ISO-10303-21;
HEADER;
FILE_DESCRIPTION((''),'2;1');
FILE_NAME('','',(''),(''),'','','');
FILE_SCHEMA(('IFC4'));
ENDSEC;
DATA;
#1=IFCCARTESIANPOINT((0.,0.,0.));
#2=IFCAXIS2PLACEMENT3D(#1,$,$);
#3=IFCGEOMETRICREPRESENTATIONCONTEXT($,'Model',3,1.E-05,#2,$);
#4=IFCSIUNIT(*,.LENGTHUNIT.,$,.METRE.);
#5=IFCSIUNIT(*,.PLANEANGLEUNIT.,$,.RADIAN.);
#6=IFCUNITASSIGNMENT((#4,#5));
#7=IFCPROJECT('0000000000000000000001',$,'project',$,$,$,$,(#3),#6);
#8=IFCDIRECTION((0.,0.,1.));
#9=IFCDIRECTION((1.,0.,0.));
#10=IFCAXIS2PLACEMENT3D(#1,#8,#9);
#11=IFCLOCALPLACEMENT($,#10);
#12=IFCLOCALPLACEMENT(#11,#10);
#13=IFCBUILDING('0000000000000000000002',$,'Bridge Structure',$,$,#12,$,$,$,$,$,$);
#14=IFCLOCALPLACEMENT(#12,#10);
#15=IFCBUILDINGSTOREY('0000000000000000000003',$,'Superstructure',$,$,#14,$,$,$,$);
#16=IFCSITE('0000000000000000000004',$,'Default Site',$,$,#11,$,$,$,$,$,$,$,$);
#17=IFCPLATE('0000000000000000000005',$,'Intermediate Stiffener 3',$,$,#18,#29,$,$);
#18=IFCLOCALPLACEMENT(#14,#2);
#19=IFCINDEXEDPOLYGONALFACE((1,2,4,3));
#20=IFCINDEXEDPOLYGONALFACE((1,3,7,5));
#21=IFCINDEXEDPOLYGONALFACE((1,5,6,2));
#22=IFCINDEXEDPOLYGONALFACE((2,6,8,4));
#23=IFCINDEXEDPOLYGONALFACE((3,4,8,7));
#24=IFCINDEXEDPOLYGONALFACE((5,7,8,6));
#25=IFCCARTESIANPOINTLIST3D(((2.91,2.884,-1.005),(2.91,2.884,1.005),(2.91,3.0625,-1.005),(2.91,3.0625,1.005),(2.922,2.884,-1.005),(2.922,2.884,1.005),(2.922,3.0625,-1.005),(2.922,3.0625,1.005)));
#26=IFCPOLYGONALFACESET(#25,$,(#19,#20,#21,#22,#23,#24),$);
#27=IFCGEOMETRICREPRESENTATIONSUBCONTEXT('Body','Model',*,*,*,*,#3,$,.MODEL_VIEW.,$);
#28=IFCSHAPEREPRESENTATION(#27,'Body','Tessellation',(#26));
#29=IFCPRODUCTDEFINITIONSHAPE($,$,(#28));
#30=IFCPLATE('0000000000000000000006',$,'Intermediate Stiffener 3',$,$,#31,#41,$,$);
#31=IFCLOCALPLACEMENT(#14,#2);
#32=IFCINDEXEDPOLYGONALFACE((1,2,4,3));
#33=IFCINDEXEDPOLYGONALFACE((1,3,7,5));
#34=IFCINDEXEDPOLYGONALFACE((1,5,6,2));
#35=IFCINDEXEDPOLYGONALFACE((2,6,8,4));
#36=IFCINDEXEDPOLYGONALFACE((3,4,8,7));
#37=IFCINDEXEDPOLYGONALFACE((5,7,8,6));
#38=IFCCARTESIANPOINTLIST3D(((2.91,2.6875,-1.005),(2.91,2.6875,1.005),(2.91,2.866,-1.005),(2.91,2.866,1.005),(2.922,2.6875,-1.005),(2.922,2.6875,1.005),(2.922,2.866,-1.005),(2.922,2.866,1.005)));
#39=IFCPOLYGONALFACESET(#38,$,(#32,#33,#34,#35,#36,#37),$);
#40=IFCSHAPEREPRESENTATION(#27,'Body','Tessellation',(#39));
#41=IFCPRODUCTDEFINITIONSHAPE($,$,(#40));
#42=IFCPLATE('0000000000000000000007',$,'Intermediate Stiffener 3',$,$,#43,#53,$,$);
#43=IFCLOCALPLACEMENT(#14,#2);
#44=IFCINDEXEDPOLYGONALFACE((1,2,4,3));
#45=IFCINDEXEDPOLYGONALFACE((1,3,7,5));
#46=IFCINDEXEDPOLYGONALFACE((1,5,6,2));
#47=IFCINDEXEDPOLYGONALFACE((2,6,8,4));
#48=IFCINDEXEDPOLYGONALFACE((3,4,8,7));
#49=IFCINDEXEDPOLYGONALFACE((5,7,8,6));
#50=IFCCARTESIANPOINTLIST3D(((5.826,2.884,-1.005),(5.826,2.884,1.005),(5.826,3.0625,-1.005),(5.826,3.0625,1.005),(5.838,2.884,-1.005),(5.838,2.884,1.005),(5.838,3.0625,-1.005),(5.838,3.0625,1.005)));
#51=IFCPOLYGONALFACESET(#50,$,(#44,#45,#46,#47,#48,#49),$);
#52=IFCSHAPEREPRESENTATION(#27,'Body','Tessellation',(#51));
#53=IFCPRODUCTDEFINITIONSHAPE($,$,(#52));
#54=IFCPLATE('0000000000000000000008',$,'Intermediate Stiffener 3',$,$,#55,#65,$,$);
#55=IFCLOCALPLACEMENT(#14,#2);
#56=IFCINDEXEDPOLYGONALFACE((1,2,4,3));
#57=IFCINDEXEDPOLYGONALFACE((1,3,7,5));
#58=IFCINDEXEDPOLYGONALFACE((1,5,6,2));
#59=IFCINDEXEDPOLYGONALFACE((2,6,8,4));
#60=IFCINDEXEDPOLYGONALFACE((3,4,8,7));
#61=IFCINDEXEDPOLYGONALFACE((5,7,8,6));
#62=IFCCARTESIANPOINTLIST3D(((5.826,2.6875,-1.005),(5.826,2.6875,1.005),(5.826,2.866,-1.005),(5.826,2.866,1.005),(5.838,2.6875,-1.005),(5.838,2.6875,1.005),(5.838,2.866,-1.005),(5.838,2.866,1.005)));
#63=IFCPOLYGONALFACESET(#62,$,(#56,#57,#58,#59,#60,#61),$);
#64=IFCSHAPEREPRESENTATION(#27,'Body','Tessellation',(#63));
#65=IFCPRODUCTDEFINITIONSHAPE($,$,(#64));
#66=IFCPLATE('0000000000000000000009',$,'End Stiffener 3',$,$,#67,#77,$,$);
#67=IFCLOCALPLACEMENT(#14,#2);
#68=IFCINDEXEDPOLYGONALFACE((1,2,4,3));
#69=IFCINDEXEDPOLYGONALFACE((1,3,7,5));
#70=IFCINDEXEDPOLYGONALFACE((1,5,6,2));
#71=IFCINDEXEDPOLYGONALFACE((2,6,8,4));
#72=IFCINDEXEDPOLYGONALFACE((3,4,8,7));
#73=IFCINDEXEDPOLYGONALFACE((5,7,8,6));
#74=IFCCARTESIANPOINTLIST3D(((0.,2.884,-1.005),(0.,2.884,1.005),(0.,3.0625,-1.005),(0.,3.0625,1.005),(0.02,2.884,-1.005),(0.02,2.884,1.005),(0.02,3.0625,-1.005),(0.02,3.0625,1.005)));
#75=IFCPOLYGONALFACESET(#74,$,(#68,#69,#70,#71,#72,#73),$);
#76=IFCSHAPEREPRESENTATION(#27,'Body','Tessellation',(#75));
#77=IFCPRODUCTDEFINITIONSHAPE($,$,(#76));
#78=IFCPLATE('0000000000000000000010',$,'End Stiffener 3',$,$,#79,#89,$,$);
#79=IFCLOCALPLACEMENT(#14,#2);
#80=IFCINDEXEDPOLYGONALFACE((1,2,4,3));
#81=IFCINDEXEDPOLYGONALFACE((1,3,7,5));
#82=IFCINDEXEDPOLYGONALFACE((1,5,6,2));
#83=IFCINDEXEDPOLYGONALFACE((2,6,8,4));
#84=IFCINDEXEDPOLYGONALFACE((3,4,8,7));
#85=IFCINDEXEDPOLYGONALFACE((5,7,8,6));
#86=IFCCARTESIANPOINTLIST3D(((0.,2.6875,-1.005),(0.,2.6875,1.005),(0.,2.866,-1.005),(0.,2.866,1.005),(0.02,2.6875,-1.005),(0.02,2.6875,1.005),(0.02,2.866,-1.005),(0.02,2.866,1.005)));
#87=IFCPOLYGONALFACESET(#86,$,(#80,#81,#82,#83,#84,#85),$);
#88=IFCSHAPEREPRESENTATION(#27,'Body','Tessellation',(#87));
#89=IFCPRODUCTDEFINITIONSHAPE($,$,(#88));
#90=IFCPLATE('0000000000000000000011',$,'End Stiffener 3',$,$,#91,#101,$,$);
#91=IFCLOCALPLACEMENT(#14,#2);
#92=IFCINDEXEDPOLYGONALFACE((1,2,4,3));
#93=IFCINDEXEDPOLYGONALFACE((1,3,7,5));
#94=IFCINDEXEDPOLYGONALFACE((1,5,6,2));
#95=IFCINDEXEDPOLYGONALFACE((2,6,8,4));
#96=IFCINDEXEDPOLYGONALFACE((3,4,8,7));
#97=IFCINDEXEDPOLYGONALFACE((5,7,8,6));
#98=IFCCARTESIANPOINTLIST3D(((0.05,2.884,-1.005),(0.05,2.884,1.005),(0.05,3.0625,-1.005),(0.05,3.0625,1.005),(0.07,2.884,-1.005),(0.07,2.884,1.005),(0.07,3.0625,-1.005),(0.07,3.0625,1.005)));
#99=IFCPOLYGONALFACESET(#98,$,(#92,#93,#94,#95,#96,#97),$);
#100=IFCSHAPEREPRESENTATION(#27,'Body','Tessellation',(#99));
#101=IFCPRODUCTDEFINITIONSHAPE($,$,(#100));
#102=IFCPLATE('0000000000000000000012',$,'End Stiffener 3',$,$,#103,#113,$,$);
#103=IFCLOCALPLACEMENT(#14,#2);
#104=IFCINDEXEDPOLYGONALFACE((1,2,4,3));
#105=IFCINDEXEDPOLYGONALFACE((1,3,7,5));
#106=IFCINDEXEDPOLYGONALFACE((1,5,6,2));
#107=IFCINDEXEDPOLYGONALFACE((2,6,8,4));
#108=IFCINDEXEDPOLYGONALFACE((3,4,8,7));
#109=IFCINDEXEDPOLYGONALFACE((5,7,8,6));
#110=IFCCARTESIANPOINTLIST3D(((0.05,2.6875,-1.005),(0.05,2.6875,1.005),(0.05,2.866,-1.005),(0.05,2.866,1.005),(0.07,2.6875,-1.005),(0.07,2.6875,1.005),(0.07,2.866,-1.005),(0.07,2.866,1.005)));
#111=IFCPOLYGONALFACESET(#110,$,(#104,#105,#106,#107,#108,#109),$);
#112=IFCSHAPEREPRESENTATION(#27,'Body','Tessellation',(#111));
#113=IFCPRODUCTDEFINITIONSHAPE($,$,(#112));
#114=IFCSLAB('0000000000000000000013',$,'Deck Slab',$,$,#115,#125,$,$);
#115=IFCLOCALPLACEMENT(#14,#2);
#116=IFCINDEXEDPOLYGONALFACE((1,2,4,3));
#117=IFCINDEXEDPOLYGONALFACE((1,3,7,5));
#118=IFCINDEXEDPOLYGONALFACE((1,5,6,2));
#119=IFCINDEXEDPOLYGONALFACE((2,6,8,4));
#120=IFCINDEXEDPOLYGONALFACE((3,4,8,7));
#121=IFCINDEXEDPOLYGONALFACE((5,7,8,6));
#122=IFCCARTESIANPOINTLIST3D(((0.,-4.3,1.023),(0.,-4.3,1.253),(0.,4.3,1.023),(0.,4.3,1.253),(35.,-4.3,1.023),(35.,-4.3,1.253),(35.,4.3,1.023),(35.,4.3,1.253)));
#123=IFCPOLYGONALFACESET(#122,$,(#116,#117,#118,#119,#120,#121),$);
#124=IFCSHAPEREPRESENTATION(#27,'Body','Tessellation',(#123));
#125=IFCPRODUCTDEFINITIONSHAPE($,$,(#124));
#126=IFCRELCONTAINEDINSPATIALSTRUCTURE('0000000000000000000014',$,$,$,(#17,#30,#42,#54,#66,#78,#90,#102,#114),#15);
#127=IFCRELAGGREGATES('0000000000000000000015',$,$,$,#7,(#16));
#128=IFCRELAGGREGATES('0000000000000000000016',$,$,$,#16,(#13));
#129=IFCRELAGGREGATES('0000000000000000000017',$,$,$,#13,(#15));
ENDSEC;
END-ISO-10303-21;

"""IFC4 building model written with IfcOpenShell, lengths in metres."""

from ifc_helpers import new_model, si_unit, frame, origin, origin_with_axes, origin_2d_with_axis, place, context, subcontext, project, spatial, polyline, rectangle, outline, extrude, element, save


model = new_model("IFC4")

# Units and contexts
model_context = context("Model", 3, precision=1e-05, world=origin())
body_context = subcontext(model_context, "Body", "Model", "MODEL_VIEW")
ifc_project = project(units=[si_unit("LENGTHUNIT", "METRE"), si_unit("PLANEANGLEUNIT", "RADIAN")], contexts=[model_context])

# Site, building, storey
site_placement = place(None, origin_with_axes())
site = spatial("IfcSite", under=ifc_project, at=site_placement, Name="Default Site")
building_placement = place(site_placement, origin_with_axes())
building = spatial("IfcBuilding", under=site, at=building_placement, Name="Bridge Structure")
storey_placement = place(building_placement, origin_with_axes())
storey = spatial("IfcBuildingStorey", under=building, at=storey_placement, Name="Superstructure")

# Plates
for number, where, z_axis, x_axis, name in (
    (1, (2.916, 2.9733, -1.005), (0.0, 0.0, 1.0), (1.0, 0.0, 0.0), "Intermediate Stiffener 3"),
    (2, (2.916, 2.7768, -1.005), (0.0, 0.0, 1.0), (1.0, 0.0, 0.0), "Intermediate Stiffener 3"),
    (3, (5.832, 2.9733, -1.005), (0.0, 0.0, 1.0), (1.0, 0.0, 0.0), "Intermediate Stiffener 3"),
    (4, (5.832, 2.7768, -1.005), (0.0, 0.0, 1.0), (1.0, 0.0, 0.0), "Intermediate Stiffener 3"),
):
    element("IfcPlate", number, at=place(storey_placement, frame(where, z_axis=z_axis, x_axis=x_axis)), inside=storey, Name=name, context=body_context, shape_type="SweptSolid", body=[
        extrude(rectangle(XDim=0.012, YDim=0.1785, at=origin_2d_with_axis()), origin_with_axes(), (0.0, 0.0, 1.0), 2.01),
    ])
for number, where, z_axis, x_axis, name in (
    (5, (0.01, 2.9733, -1.005), (0.0, 0.0, 1.0), (1.0, 0.0, 0.0), "End Stiffener 3"),
    (6, (0.01, 2.7768, -1.005), (0.0, 0.0, 1.0), (1.0, 0.0, 0.0), "End Stiffener 3"),
    (7, (0.06, 2.9733, -1.005), (0.0, 0.0, 1.0), (1.0, 0.0, 0.0), "End Stiffener 3"),
    (8, (0.06, 2.7768, -1.005), (0.0, 0.0, 1.0), (1.0, 0.0, 0.0), "End Stiffener 3"),
):
    element("IfcPlate", number, at=place(storey_placement, frame(where, z_axis=z_axis, x_axis=x_axis)), inside=storey, Name=name, context=body_context, shape_type="SweptSolid", body=[
        extrude(rectangle(XDim=0.02, YDim=0.1785, at=origin_2d_with_axis()), origin_with_axes(), (0.0, 0.0, 1.0), 2.01),
    ])

# Slab
slab_placement = place(storey_placement, frame((0.0, 0.0, 1.023), z_axis=(0.0, 0.0, 1.0), x_axis=(1.0, 0.0, 0.0)))
element("IfcSlab", 9, at=slab_placement, inside=storey, Name="Deck Slab", context=body_context, shape_type="SweptSolid", body=[
    extrude(outline(polyline([(0.0, -4.3), (35.0, -4.3), (35.0, 4.3), (0.0, 4.3), (0.0, -4.3)])), origin_with_axes(), (0.0, 0.0, 1.0), 0.23),
])

save(model, "model.ifc")
